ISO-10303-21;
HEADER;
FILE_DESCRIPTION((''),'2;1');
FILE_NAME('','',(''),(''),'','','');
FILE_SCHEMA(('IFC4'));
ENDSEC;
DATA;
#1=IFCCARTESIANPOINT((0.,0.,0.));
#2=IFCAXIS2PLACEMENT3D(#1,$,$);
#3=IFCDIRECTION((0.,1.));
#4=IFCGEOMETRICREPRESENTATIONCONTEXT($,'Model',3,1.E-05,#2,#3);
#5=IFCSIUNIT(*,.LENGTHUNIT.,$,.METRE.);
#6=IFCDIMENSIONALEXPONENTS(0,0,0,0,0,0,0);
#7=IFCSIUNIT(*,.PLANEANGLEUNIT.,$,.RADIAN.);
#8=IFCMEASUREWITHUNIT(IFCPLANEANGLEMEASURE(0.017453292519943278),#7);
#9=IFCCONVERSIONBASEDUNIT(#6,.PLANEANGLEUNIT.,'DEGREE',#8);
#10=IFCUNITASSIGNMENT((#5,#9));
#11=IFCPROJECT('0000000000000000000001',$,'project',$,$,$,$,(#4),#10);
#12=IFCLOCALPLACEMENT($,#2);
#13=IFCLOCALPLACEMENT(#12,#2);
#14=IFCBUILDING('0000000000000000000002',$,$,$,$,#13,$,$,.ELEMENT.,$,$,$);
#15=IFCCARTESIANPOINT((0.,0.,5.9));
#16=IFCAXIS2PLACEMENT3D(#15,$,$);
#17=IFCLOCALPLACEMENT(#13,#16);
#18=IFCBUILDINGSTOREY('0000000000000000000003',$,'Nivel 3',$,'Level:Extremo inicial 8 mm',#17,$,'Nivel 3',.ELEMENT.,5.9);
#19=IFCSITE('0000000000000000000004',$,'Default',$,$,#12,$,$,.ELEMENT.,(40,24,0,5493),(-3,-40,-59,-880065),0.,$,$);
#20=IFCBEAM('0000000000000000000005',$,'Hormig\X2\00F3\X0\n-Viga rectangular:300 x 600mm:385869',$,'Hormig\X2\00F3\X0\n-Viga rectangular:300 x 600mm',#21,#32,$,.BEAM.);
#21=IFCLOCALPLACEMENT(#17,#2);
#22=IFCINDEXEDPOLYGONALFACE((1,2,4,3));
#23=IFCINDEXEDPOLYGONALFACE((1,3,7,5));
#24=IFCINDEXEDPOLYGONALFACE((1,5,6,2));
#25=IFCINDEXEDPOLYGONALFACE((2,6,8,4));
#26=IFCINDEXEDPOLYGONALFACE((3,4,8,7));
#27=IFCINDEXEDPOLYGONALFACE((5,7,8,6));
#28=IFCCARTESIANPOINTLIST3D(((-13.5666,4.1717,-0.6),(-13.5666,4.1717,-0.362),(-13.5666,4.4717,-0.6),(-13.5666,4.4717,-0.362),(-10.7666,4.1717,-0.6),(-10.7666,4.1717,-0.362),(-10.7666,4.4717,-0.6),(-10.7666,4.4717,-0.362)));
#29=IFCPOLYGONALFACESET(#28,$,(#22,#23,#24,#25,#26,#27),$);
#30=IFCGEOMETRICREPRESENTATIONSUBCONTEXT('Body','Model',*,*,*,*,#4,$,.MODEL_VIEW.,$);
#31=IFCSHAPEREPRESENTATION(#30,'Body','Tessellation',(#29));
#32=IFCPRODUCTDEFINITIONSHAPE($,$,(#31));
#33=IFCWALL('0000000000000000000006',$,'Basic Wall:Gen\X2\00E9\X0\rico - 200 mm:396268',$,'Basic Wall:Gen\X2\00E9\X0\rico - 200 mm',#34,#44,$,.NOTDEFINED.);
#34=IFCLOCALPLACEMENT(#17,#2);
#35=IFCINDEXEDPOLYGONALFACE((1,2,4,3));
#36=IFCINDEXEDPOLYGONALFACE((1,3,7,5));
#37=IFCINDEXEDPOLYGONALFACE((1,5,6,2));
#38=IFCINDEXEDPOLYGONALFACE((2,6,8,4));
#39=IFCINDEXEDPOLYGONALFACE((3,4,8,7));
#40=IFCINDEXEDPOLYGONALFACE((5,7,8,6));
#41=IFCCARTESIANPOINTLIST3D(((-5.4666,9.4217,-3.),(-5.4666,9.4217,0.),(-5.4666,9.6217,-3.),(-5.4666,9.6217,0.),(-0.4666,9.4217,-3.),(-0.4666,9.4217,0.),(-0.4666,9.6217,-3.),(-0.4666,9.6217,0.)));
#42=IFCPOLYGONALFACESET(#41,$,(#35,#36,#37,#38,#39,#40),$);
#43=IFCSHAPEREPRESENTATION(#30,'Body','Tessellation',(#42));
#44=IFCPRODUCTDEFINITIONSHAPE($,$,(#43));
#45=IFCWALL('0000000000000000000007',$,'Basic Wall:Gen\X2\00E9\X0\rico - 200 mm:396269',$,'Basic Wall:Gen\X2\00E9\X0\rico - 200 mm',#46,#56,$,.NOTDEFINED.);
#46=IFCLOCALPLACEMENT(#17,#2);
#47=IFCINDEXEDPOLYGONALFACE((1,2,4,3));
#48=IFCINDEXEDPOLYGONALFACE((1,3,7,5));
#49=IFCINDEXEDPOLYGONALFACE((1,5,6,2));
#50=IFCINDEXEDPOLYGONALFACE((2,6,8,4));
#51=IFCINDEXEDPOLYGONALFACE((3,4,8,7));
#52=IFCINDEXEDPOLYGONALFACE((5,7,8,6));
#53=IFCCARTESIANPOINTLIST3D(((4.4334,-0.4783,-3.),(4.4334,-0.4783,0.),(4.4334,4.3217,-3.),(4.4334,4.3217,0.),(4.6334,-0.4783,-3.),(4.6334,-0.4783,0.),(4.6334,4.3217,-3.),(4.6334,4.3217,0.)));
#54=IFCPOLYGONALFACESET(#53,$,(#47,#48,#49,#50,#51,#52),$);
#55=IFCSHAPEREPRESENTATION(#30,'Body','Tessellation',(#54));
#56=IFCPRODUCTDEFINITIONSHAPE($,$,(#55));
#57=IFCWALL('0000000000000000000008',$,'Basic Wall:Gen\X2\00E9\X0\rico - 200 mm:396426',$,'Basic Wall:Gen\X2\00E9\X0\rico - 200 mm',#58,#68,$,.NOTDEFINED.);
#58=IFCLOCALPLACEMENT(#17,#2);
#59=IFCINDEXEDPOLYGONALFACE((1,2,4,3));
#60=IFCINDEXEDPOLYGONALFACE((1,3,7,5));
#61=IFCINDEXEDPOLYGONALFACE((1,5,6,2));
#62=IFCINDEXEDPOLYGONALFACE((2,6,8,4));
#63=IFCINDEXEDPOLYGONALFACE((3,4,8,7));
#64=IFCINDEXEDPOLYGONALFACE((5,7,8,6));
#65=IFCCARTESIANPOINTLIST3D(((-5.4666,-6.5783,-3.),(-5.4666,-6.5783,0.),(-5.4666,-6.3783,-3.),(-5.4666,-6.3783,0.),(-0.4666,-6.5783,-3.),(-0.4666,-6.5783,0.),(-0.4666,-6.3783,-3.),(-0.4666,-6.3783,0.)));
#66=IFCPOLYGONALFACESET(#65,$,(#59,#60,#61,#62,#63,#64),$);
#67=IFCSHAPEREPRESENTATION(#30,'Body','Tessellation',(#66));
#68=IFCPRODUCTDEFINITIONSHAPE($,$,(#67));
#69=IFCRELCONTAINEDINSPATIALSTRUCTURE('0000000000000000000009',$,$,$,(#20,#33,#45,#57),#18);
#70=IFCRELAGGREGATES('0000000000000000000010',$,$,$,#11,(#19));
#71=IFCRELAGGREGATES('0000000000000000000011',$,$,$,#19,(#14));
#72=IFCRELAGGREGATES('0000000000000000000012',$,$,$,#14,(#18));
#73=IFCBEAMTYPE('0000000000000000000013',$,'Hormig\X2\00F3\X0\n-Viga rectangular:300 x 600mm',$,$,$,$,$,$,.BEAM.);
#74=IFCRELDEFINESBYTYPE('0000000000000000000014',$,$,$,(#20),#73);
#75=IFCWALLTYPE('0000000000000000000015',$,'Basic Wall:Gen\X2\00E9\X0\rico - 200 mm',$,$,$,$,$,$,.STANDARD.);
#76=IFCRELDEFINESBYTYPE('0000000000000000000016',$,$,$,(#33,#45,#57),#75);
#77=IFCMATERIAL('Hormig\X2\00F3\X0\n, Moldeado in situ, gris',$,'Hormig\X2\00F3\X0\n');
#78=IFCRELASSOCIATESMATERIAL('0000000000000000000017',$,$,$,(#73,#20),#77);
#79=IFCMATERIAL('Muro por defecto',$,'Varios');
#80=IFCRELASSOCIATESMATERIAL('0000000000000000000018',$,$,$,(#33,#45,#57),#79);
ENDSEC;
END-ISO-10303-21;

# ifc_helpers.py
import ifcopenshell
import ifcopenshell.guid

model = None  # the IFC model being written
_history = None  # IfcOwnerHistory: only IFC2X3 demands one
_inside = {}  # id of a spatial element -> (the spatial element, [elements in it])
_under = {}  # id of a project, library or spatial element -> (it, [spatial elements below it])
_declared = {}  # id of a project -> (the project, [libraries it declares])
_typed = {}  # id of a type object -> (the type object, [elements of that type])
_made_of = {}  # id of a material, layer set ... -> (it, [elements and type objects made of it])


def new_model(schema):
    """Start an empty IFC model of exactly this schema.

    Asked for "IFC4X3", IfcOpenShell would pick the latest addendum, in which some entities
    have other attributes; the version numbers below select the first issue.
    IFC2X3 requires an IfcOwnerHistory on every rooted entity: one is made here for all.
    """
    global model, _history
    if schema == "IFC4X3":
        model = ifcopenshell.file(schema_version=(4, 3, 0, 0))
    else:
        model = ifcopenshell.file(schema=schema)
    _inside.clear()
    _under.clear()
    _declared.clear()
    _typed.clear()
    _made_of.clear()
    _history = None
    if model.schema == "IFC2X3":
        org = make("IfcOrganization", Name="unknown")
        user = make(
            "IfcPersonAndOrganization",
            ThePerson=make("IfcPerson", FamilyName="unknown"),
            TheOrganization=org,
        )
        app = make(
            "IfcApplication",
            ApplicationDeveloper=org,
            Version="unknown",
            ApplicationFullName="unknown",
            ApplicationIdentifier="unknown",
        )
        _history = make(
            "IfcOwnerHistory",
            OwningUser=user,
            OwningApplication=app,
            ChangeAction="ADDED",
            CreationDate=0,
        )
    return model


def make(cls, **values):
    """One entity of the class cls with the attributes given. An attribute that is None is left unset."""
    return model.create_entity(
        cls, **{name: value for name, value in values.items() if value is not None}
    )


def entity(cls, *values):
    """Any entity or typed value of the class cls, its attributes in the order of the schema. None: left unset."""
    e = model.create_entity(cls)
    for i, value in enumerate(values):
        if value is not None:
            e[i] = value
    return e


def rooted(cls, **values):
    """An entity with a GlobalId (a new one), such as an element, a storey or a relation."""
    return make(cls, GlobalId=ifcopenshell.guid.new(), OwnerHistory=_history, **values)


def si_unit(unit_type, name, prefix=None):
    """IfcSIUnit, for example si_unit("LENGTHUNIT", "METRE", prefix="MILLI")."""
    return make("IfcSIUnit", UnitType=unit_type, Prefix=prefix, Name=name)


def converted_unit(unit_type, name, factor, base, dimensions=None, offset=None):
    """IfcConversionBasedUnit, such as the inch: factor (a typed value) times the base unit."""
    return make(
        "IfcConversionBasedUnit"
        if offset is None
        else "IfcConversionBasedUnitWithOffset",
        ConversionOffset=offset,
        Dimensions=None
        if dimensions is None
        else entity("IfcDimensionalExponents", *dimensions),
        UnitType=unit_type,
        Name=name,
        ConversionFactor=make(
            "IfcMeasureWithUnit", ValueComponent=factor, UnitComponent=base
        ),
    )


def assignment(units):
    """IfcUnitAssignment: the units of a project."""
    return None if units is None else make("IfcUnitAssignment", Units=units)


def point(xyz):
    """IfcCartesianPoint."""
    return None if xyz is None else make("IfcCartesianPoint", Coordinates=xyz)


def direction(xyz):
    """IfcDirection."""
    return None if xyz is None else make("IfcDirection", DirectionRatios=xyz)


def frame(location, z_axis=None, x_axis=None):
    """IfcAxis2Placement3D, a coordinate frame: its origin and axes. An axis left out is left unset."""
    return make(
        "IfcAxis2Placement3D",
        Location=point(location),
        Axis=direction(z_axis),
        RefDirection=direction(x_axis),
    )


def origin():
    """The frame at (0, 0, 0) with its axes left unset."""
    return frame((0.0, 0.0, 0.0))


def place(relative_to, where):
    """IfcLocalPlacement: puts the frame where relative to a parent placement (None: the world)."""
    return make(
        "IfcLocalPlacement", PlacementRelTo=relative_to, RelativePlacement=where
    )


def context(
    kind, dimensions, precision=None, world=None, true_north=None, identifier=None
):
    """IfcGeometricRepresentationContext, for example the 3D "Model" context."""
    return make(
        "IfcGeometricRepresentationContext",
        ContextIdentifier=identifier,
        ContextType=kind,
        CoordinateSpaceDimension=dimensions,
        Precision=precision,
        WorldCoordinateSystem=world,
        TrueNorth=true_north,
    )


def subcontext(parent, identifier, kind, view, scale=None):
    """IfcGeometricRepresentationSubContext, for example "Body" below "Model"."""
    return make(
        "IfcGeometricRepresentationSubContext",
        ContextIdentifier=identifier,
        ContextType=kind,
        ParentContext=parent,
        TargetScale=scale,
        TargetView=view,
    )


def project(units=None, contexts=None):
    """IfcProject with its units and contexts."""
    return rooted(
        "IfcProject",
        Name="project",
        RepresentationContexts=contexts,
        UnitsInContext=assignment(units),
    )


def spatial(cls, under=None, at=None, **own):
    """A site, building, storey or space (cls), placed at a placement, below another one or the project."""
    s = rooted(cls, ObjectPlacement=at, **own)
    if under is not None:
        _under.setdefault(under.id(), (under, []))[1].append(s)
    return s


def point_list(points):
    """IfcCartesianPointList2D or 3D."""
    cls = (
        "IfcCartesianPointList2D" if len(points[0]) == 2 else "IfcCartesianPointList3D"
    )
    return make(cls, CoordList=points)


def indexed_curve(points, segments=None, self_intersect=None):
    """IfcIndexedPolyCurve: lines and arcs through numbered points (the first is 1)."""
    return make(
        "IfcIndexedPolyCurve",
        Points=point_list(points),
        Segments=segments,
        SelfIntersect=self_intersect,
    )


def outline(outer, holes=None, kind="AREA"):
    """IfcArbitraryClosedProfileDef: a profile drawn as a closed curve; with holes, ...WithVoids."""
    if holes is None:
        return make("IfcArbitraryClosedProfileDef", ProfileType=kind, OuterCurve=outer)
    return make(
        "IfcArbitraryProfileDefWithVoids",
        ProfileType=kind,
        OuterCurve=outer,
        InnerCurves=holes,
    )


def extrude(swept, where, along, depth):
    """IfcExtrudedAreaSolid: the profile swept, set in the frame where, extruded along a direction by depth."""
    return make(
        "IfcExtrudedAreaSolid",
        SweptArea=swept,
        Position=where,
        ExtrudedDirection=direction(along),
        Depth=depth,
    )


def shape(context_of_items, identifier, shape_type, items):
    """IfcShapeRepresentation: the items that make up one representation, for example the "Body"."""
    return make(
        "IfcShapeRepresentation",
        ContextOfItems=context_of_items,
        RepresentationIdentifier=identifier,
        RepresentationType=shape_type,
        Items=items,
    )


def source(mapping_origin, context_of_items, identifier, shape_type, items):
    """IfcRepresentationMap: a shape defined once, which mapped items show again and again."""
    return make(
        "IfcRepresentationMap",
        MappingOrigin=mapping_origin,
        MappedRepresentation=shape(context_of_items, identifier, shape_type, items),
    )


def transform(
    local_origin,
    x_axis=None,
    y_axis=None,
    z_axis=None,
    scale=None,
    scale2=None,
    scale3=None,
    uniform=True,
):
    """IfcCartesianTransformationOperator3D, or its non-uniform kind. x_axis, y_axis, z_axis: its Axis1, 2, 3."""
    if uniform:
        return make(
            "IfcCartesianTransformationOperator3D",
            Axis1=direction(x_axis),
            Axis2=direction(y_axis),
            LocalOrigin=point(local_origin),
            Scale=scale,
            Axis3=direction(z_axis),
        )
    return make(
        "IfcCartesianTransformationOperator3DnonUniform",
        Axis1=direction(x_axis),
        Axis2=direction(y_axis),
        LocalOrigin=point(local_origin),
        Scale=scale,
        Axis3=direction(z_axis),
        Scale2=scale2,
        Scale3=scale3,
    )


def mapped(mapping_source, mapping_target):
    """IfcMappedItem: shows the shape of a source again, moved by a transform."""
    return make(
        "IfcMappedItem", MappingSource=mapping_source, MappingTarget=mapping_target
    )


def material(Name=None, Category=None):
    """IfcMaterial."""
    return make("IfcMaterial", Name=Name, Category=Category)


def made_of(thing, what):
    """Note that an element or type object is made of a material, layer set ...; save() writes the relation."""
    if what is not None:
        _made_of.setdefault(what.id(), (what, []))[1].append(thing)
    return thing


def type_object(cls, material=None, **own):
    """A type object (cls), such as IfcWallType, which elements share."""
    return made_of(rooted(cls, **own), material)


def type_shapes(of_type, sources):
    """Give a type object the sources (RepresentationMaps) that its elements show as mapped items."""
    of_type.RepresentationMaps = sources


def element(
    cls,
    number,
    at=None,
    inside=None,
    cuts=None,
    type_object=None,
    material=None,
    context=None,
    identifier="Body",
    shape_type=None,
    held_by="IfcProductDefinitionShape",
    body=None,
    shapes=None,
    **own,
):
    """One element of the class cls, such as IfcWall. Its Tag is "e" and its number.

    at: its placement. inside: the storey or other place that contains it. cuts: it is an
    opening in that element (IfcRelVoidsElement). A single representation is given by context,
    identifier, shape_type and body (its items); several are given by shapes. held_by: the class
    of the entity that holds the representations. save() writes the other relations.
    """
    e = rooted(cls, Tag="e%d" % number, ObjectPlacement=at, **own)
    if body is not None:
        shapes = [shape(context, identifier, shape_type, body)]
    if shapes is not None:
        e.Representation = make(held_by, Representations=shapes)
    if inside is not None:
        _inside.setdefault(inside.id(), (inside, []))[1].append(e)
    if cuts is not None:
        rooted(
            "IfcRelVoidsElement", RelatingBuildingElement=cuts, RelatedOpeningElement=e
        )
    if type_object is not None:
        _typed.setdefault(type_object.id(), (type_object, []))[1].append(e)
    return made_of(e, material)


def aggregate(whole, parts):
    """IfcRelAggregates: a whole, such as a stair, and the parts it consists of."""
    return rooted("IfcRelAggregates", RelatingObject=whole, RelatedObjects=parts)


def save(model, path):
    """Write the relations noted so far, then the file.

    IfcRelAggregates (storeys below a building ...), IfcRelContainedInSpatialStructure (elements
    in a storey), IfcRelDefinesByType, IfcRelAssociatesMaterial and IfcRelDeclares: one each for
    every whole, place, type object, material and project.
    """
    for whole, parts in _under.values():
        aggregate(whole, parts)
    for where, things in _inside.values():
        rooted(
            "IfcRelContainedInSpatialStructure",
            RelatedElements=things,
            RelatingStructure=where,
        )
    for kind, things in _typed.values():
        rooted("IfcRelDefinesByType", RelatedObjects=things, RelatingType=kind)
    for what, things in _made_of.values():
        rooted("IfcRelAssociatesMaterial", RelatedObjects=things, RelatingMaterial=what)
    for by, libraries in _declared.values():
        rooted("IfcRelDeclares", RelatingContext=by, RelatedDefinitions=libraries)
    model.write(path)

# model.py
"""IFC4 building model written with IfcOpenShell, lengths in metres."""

from ifc_helpers import new_model, entity, si_unit, converted_unit, direction, frame, origin, place, context, subcontext, project, spatial, indexed_curve, outline, extrude, source, transform, mapped, material, type_object, type_shapes, element, save


model = new_model("IFC4")

# Units and contexts
model_context = context("Model", 3, precision=1e-05, world=origin(), true_north=direction((0.0, 1.0)))
body_context = subcontext(model_context, "Body", "Model", "MODEL_VIEW")
ifc_project = project(units=[si_unit("LENGTHUNIT", "METRE"), converted_unit("PLANEANGLEUNIT", "DEGREE", entity("IfcPlaneAngleMeasure", 0.017453292519943278), si_unit("PLANEANGLEUNIT", "RADIAN"), dimensions=[0, 0, 0, 0, 0, 0, 0])], contexts=[model_context])

# Site, building, storey
site_placement = place(None, origin())
site = spatial("IfcSite", under=ifc_project, at=site_placement, Name="Default", CompositionType="ELEMENT", RefLatitude=(40, 24, 0, 5493), RefLongitude=(-3, -40, -59, -880065), RefElevation=0.0)
building_placement = place(site_placement, origin())
building = spatial("IfcBuilding", under=site, at=building_placement, CompositionType="ELEMENT")
storey_placement = place(building_placement, frame((0.0, 0.0, 5.9)))
storey = spatial("IfcBuildingStorey", under=building, at=storey_placement, Name="Nivel 3", ObjectType="Level:Extremo inicial 8 mm", LongName="Nivel 3", CompositionType="ELEMENT", Elevation=5.9)

# Shared definitions
ifc_material_1 = material(Name="Hormigón, Moldeado in situ, gris", Category="Hormigón")

# Beam
beam_type_1 = type_object("IfcBeamType", Name="Hormigón-Viga rectangular:300 x 600mm", PredefinedType="BEAM", material=ifc_material_1)
shared_shape_1 = source(origin(), body_context, "Body", "SweptSolid", [
    extrude(outline(indexed_curve([(-0.119, -0.15), (0.119, -0.15), (0.119, 0.15), (-0.119, 0.15), (-0.119, -0.15)], self_intersect=False)), frame((-10.7666, 4.3217, 5.419), z_axis=(-1.0, 0.0, 0.0), x_axis=(0.0, 0.0, -1.0)), (0.0, 0.0, 1.0), 2.8),
])
type_shapes(beam_type_1, [shared_shape_1])
beam_1_placement = place(storey_placement, frame((0.0, 0.0, -5.9)))
element("IfcBeam", 1, at=beam_1_placement, inside=storey, type_object=beam_type_1, material=ifc_material_1, Name="Hormigón-Viga rectangular:300 x 600mm:385869", ObjectType="Hormigón-Viga rectangular:300 x 600mm", PredefinedType="BEAM", context=body_context, shape_type="MappedRepresentation", body=[
    mapped(shared_shape_1, transform((0.0, 0.0, 0.0), scale=1.0)),
])

# Walls
ifc_material_2 = material(Name="Muro por defecto", Category="Varios")
wall_type = type_object("IfcWallType", Name="Basic Wall:Genérico - 200 mm", PredefinedType="STANDARD")
wall_1_placement = place(storey_placement, frame((-5.4666, 9.5217, -3.0)))
element("IfcWall", 2, at=wall_1_placement, inside=storey, type_object=wall_type, material=ifc_material_2, Name="Basic Wall:Genérico - 200 mm:396268", ObjectType="Basic Wall:Genérico - 200 mm", PredefinedType="NOTDEFINED", context=body_context, shape_type="SweptSolid", body=[
    extrude(outline(indexed_curve([(5.0, 0.1), (0.0, 0.1), (0.0, -0.1), (5.0, -0.1), (5.0, 0.1)], self_intersect=False)), origin(), (0.0, 0.0, 1.0), 3.0),
])
wall_2_placement = place(storey_placement, frame((4.5334, 4.3217, -3.0), z_axis=(0.0, 0.0, 1.0), x_axis=(0.0, -1.0, 0.0)))
element("IfcWall", 3, at=wall_2_placement, inside=storey, type_object=wall_type, material=ifc_material_2, Name="Basic Wall:Genérico - 200 mm:396269", ObjectType="Basic Wall:Genérico - 200 mm", PredefinedType="NOTDEFINED", context=body_context, shape_type="SweptSolid", body=[
    extrude(outline(indexed_curve([(4.8, 0.1), (0.0, 0.1), (0.0, -0.1), (4.8, -0.1), (4.8, 0.1)], self_intersect=False)), origin(), (0.0, 0.0, 1.0), 3.0),
])
wall_3_placement = place(storey_placement, frame((-5.4666, -6.4783, -3.0)))
element("IfcWall", 4, at=wall_3_placement, inside=storey, type_object=wall_type, material=ifc_material_2, Name="Basic Wall:Genérico - 200 mm:396426", ObjectType="Basic Wall:Genérico - 200 mm", PredefinedType="NOTDEFINED", context=body_context, shape_type="SweptSolid", body=[
    extrude(outline(indexed_curve([(5.0, 0.1), (0.0, 0.1), (0.0, -0.1), (5.0, -0.1), (5.0, 0.1)], self_intersect=False)), origin(), (0.0, 0.0, 1.0), 3.0),
])

save(model, "model.ifc")
